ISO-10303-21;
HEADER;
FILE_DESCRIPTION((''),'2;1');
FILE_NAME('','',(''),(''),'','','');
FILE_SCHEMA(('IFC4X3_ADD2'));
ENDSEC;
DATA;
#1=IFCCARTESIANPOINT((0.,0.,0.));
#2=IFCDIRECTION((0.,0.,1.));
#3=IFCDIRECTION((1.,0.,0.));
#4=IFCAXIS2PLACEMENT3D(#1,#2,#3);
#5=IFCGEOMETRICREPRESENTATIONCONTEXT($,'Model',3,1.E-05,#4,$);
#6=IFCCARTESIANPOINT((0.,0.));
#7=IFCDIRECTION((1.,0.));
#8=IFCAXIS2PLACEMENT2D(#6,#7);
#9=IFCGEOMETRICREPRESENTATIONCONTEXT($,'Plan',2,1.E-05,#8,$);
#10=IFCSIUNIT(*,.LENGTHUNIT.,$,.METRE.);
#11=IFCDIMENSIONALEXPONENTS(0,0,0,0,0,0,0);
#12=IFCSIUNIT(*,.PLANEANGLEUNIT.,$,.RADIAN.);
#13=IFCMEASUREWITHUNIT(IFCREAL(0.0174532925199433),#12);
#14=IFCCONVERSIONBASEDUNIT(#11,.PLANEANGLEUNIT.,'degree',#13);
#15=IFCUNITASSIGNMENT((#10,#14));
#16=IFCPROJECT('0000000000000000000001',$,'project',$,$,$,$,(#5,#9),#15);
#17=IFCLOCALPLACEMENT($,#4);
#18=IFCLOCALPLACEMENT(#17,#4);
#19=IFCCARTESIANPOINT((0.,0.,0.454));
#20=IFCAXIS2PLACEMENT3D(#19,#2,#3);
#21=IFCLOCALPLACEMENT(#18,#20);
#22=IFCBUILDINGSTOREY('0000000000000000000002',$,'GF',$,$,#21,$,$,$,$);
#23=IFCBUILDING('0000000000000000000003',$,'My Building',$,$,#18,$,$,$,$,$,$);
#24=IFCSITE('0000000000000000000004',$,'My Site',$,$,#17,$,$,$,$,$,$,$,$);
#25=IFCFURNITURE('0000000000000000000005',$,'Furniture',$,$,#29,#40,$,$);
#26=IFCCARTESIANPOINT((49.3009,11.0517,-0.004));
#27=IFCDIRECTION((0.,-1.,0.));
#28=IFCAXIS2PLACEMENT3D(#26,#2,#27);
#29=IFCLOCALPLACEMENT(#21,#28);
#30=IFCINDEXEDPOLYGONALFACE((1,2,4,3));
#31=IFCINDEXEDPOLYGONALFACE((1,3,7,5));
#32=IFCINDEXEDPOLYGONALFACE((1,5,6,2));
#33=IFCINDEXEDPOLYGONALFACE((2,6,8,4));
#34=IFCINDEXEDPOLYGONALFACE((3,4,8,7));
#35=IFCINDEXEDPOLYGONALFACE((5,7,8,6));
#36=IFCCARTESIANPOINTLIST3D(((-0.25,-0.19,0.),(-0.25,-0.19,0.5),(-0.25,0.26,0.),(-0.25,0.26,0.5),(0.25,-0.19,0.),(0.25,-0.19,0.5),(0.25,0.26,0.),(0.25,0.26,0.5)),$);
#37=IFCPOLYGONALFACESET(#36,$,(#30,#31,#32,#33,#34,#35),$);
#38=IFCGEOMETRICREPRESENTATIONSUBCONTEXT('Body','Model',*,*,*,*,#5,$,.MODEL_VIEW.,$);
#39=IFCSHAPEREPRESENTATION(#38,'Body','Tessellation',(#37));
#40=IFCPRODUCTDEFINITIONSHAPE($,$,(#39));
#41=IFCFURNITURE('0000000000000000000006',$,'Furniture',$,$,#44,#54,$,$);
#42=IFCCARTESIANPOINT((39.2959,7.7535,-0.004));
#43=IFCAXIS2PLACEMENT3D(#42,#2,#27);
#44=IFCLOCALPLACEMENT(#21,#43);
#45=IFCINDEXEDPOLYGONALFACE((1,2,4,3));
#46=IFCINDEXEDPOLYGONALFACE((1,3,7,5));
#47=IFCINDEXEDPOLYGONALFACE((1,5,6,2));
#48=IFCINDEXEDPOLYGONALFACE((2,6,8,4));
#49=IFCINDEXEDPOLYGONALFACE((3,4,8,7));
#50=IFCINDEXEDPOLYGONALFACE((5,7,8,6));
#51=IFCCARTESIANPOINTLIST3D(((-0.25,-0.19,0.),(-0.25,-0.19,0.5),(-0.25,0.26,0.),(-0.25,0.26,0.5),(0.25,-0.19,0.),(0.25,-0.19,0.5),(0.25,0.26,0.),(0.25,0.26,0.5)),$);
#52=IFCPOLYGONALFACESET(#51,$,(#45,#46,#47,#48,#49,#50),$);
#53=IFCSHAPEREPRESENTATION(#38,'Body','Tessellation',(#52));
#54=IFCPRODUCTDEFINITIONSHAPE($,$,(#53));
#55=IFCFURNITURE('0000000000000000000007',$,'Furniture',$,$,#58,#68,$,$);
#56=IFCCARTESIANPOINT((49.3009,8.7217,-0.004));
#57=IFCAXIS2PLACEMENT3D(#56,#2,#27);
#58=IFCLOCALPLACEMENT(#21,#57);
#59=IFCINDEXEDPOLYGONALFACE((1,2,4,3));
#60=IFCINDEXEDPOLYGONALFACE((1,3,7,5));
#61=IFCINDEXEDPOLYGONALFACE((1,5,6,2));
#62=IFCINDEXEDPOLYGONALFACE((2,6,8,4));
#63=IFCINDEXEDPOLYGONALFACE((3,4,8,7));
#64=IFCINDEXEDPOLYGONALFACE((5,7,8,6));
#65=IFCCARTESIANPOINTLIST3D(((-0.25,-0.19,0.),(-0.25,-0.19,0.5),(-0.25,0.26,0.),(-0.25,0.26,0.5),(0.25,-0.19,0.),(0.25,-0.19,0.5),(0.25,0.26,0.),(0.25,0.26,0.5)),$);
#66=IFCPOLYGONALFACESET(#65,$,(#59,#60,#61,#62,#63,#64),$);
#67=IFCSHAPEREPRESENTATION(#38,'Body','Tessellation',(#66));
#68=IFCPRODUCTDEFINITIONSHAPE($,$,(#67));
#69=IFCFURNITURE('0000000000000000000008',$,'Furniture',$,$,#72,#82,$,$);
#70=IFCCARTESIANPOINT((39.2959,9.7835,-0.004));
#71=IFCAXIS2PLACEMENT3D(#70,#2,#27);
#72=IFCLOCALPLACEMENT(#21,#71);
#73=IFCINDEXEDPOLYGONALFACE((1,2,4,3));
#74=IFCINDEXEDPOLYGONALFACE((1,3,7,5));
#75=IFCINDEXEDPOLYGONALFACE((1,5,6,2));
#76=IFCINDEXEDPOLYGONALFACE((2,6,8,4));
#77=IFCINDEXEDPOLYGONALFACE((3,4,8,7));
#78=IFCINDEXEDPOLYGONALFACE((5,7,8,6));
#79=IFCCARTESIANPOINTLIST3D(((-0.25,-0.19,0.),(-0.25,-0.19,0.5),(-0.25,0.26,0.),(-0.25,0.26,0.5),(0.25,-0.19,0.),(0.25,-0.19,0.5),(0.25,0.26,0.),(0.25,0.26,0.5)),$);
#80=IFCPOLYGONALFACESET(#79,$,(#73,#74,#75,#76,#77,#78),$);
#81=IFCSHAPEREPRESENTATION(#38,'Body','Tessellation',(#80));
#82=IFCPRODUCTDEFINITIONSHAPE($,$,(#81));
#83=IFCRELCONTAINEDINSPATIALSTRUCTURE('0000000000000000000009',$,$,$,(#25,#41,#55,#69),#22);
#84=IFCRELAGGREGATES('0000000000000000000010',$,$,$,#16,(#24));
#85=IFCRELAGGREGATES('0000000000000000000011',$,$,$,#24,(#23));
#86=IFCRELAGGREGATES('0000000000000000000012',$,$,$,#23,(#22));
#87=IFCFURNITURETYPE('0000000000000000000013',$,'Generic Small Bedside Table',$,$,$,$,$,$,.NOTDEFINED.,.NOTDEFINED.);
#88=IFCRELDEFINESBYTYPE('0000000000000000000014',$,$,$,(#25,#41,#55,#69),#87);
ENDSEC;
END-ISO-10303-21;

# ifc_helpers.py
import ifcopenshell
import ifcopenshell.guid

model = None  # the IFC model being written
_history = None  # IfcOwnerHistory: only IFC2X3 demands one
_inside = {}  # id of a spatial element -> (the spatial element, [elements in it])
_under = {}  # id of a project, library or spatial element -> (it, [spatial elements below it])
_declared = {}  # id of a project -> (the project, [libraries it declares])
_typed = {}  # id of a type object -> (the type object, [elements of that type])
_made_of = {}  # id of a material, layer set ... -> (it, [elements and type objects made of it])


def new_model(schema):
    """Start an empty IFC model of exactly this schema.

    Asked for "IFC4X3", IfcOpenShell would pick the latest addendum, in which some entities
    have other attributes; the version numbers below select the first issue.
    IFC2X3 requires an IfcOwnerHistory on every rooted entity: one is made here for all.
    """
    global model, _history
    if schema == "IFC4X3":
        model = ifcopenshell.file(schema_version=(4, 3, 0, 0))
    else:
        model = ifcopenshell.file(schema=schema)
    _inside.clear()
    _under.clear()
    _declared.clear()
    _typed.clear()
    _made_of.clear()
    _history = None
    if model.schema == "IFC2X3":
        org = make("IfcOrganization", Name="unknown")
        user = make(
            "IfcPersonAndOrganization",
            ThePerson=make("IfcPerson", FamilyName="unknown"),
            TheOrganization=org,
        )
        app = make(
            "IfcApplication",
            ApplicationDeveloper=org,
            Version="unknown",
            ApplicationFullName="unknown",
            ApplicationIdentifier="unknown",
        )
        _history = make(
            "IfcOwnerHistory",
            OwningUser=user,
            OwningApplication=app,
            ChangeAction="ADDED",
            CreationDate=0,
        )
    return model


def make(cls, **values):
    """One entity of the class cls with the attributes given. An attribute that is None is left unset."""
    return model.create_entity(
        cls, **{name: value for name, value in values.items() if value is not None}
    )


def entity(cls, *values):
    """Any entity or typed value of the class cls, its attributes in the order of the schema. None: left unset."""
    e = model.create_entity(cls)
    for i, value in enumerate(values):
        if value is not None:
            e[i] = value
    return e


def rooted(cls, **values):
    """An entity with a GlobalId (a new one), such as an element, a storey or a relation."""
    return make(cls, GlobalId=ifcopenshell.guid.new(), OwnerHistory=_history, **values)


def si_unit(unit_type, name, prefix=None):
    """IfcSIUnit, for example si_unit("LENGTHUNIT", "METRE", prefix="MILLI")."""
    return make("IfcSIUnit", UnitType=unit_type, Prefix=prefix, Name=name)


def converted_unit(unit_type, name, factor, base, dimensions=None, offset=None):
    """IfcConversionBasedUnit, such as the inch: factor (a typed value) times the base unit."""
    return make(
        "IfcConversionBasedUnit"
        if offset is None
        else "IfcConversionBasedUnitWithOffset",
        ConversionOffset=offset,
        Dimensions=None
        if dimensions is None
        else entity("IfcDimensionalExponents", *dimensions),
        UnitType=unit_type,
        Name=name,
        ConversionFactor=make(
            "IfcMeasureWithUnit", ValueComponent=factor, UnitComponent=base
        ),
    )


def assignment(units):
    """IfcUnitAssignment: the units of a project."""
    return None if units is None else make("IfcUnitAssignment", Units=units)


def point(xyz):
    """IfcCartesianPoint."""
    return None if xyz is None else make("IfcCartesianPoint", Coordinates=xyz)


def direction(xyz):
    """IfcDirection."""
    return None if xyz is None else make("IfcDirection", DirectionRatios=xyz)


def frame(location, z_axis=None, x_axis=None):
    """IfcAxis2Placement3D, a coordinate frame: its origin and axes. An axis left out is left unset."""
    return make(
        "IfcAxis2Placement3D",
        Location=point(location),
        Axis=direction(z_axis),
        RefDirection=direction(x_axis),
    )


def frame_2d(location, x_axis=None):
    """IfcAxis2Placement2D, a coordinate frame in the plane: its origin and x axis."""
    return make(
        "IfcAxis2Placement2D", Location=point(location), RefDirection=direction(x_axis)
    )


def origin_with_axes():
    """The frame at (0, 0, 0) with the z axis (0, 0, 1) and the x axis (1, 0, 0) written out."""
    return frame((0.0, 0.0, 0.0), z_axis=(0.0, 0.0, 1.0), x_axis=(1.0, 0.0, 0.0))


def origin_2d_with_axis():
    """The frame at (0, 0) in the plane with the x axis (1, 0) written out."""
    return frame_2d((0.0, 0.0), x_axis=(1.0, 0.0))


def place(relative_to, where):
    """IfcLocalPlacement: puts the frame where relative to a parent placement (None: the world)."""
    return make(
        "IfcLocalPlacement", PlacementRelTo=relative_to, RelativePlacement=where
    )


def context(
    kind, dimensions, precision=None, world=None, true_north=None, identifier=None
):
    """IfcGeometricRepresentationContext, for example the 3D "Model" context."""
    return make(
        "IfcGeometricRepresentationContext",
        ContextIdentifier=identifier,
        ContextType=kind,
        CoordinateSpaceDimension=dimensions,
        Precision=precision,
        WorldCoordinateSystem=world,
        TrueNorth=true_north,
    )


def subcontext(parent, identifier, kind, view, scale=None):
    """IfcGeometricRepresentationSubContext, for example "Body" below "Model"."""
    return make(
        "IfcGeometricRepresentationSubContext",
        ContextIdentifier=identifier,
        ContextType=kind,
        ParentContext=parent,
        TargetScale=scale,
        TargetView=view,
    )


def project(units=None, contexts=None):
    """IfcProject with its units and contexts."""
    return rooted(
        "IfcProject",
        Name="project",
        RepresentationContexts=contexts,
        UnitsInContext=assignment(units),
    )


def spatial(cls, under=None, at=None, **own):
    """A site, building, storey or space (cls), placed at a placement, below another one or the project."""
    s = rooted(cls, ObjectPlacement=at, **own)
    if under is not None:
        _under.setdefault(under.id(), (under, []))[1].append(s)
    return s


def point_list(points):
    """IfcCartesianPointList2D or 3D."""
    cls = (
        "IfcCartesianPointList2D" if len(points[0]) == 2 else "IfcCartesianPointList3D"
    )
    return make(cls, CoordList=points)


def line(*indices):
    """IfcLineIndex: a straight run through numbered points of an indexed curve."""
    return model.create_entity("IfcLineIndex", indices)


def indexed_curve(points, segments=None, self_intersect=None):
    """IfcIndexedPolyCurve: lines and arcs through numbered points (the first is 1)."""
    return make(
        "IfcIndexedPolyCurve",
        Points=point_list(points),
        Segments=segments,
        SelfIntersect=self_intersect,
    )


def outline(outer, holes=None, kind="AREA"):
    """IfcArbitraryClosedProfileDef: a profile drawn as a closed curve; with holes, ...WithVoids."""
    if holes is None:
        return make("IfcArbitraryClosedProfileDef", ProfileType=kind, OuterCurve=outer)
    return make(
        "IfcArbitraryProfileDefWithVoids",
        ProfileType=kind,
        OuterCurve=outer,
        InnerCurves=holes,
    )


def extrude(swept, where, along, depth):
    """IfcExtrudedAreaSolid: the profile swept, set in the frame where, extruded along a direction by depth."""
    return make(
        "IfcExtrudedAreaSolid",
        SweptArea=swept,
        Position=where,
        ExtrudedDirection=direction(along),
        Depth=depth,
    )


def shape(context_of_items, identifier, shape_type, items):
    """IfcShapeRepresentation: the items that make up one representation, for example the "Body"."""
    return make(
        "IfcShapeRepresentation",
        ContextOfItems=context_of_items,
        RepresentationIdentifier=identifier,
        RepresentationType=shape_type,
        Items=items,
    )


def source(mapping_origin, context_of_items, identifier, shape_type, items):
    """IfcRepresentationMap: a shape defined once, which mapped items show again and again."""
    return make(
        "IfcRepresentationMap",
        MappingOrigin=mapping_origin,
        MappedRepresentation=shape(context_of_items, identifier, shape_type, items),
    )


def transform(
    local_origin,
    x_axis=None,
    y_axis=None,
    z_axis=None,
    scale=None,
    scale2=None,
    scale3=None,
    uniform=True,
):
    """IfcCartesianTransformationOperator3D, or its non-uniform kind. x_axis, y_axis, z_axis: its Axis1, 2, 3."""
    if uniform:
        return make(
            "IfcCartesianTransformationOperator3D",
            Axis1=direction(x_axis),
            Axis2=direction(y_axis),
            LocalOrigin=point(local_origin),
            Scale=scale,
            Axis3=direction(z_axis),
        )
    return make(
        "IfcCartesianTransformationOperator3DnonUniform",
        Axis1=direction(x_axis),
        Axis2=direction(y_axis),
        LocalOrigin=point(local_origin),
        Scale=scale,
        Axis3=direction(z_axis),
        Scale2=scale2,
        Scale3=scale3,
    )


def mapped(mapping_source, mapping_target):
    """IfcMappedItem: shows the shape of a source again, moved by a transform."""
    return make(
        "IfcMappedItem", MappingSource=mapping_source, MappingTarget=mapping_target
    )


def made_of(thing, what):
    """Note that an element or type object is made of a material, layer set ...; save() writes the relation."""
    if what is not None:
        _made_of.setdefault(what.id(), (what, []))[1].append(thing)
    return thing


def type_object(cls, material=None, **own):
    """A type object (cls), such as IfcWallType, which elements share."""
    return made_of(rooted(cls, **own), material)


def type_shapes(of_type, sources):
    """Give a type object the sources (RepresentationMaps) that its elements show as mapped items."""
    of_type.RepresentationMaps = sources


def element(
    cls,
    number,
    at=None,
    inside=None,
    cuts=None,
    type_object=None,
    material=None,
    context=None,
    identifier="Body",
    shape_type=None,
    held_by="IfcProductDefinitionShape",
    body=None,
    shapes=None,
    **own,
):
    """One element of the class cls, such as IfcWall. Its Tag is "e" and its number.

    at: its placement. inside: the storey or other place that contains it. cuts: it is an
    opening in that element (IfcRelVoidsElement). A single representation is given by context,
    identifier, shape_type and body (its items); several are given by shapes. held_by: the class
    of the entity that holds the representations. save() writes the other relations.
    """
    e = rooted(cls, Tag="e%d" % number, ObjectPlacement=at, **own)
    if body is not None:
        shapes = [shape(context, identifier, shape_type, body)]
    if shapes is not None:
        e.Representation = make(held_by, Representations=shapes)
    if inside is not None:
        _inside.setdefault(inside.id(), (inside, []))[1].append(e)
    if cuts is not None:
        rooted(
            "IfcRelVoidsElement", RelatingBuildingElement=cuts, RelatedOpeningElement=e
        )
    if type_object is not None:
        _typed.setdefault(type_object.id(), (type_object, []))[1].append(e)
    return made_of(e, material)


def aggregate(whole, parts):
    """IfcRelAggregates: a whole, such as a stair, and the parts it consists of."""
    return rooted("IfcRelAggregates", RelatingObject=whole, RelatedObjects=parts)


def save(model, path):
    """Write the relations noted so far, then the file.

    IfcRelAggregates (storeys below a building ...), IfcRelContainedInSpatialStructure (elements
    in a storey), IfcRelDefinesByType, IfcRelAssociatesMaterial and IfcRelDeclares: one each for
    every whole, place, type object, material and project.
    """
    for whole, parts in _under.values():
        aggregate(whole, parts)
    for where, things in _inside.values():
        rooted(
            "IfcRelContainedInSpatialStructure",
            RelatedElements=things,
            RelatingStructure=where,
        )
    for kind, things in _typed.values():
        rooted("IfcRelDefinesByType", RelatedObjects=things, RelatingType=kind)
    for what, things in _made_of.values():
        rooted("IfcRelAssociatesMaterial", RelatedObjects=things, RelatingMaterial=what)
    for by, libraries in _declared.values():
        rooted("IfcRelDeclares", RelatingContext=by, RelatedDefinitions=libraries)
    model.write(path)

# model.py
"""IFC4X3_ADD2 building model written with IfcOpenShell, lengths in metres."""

from ifc_helpers import new_model, entity, si_unit, converted_unit, frame, origin_with_axes, origin_2d_with_axis, place, context, subcontext, project, spatial, line, indexed_curve, outline, extrude, shape, source, transform, mapped, type_object, type_shapes, element, save


model = new_model("IFC4X3_ADD2")

# Units and contexts
model_context = context("Model", 3, precision=1e-05, world=origin_with_axes())
plan_context = context("Plan", 2, precision=1e-05, world=origin_2d_with_axis())
body_context_1 = subcontext(model_context, "Body", "Model", "MODEL_VIEW")
body_context_2 = subcontext(plan_context, "Body", "Plan", "PLAN_VIEW")
ifc_project = project(units=[si_unit("LENGTHUNIT", "METRE"), converted_unit("PLANEANGLEUNIT", "degree", entity("IfcReal", 0.0174532925199433), si_unit("PLANEANGLEUNIT", "RADIAN"), dimensions=[0, 0, 0, 0, 0, 0, 0])], contexts=[model_context, plan_context])

# Site, building, storey
site_placement = place(None, origin_with_axes())
site = spatial("IfcSite", under=ifc_project, at=site_placement, Name="My Site")
building_placement = place(site_placement, origin_with_axes())
building = spatial("IfcBuilding", under=site, at=building_placement, Name="My Building")
storey_placement = place(building_placement, frame((0.0, 0.0, 0.454), z_axis=(0.0, 0.0, 1.0), x_axis=(1.0, 0.0, 0.0)))
storey = spatial("IfcBuildingStorey", under=building, at=storey_placement, Name="GF")

# Furniture
furniture_type_1 = type_object("IfcFurnitureType", Name="Generic Small Bedside Table", AssemblyPlace="NOTDEFINED", PredefinedType="NOTDEFINED")
shared_shape_1 = source(origin_with_axes(), body_context_1, "Body", "SweptSolid", [
    extrude(outline(indexed_curve([(0.5, 0.45), (0.5, 0.0), (0.0, 0.0), (0.0, 0.45)], segments=[line(4, 1), line(1, 2), line(2, 3), line(3, 4)], self_intersect=False)), frame((-0.25, -0.19, 0.0), z_axis=(0.0, 0.0, 1.0), x_axis=(1.0, 0.0, 0.0)), (0.0, 0.0, 1.0), 0.5),
])
shared_shape_2 = source(origin_with_axes(), body_context_2, "Body", "Annotation2D", [
    entity("IfcGeometricCurveSet", [entity("IfcIndexedPolyCurve", entity("IfcCartesianPointList2D", [[-0.25, -0.19], [0.25, -0.19], [0.25, 0.26], [-0.25, 0.26]]), [entity("IfcLineIndex", [1, 2]), entity("IfcLineIndex", [2, 3]), entity("IfcLineIndex", [3, 4]), entity("IfcLineIndex", [4, 1])])]),
])
type_shapes(furniture_type_1, [shared_shape_1, shared_shape_2])
for number, where, z_axis, x_axis, name in (
    (1, (49.3009, 11.0517, -0.004), (0.0, 0.0, 1.0), (0.0, -1.0, 0.0), "Furniture"),
    (2, (39.2959, 7.7535, -0.004), (0.0, 0.0, 1.0), (0.0, -1.0, 0.0), "Furniture"),
    (3, (49.3009, 8.7217, -0.004), (0.0, 0.0, 1.0), (0.0, -1.0, 0.0), "Furniture"),
    (4, (39.2959, 9.7835, -0.004), (0.0, 0.0, 1.0), (0.0, -1.0, 0.0), "Furniture"),
):
    element("IfcFurniture", number, at=place(storey_placement, frame(where, z_axis=z_axis, x_axis=x_axis)), inside=storey, type_object=furniture_type_1, Name=name, shapes=[
        shape(body_context_1, "Body", "MappedRepresentation", [mapped(shared_shape_1, transform((0.0, 0.0, 0.0), x_axis=(1.0, 0.0, 0.0), y_axis=(0.0, 1.0, 0.0), z_axis=(0.0, 0.0, 1.0), scale=1.0))]),
        shape(body_context_2, "Body", "MappedRepresentation", [mapped(shared_shape_2, transform((0.0, 0.0, 0.0), x_axis=(1.0, 0.0, 0.0), y_axis=(0.0, 1.0, 0.0), z_axis=(0.0, 0.0, 1.0), scale=1.0))]),
    ])

save(model, "model.ifc")
